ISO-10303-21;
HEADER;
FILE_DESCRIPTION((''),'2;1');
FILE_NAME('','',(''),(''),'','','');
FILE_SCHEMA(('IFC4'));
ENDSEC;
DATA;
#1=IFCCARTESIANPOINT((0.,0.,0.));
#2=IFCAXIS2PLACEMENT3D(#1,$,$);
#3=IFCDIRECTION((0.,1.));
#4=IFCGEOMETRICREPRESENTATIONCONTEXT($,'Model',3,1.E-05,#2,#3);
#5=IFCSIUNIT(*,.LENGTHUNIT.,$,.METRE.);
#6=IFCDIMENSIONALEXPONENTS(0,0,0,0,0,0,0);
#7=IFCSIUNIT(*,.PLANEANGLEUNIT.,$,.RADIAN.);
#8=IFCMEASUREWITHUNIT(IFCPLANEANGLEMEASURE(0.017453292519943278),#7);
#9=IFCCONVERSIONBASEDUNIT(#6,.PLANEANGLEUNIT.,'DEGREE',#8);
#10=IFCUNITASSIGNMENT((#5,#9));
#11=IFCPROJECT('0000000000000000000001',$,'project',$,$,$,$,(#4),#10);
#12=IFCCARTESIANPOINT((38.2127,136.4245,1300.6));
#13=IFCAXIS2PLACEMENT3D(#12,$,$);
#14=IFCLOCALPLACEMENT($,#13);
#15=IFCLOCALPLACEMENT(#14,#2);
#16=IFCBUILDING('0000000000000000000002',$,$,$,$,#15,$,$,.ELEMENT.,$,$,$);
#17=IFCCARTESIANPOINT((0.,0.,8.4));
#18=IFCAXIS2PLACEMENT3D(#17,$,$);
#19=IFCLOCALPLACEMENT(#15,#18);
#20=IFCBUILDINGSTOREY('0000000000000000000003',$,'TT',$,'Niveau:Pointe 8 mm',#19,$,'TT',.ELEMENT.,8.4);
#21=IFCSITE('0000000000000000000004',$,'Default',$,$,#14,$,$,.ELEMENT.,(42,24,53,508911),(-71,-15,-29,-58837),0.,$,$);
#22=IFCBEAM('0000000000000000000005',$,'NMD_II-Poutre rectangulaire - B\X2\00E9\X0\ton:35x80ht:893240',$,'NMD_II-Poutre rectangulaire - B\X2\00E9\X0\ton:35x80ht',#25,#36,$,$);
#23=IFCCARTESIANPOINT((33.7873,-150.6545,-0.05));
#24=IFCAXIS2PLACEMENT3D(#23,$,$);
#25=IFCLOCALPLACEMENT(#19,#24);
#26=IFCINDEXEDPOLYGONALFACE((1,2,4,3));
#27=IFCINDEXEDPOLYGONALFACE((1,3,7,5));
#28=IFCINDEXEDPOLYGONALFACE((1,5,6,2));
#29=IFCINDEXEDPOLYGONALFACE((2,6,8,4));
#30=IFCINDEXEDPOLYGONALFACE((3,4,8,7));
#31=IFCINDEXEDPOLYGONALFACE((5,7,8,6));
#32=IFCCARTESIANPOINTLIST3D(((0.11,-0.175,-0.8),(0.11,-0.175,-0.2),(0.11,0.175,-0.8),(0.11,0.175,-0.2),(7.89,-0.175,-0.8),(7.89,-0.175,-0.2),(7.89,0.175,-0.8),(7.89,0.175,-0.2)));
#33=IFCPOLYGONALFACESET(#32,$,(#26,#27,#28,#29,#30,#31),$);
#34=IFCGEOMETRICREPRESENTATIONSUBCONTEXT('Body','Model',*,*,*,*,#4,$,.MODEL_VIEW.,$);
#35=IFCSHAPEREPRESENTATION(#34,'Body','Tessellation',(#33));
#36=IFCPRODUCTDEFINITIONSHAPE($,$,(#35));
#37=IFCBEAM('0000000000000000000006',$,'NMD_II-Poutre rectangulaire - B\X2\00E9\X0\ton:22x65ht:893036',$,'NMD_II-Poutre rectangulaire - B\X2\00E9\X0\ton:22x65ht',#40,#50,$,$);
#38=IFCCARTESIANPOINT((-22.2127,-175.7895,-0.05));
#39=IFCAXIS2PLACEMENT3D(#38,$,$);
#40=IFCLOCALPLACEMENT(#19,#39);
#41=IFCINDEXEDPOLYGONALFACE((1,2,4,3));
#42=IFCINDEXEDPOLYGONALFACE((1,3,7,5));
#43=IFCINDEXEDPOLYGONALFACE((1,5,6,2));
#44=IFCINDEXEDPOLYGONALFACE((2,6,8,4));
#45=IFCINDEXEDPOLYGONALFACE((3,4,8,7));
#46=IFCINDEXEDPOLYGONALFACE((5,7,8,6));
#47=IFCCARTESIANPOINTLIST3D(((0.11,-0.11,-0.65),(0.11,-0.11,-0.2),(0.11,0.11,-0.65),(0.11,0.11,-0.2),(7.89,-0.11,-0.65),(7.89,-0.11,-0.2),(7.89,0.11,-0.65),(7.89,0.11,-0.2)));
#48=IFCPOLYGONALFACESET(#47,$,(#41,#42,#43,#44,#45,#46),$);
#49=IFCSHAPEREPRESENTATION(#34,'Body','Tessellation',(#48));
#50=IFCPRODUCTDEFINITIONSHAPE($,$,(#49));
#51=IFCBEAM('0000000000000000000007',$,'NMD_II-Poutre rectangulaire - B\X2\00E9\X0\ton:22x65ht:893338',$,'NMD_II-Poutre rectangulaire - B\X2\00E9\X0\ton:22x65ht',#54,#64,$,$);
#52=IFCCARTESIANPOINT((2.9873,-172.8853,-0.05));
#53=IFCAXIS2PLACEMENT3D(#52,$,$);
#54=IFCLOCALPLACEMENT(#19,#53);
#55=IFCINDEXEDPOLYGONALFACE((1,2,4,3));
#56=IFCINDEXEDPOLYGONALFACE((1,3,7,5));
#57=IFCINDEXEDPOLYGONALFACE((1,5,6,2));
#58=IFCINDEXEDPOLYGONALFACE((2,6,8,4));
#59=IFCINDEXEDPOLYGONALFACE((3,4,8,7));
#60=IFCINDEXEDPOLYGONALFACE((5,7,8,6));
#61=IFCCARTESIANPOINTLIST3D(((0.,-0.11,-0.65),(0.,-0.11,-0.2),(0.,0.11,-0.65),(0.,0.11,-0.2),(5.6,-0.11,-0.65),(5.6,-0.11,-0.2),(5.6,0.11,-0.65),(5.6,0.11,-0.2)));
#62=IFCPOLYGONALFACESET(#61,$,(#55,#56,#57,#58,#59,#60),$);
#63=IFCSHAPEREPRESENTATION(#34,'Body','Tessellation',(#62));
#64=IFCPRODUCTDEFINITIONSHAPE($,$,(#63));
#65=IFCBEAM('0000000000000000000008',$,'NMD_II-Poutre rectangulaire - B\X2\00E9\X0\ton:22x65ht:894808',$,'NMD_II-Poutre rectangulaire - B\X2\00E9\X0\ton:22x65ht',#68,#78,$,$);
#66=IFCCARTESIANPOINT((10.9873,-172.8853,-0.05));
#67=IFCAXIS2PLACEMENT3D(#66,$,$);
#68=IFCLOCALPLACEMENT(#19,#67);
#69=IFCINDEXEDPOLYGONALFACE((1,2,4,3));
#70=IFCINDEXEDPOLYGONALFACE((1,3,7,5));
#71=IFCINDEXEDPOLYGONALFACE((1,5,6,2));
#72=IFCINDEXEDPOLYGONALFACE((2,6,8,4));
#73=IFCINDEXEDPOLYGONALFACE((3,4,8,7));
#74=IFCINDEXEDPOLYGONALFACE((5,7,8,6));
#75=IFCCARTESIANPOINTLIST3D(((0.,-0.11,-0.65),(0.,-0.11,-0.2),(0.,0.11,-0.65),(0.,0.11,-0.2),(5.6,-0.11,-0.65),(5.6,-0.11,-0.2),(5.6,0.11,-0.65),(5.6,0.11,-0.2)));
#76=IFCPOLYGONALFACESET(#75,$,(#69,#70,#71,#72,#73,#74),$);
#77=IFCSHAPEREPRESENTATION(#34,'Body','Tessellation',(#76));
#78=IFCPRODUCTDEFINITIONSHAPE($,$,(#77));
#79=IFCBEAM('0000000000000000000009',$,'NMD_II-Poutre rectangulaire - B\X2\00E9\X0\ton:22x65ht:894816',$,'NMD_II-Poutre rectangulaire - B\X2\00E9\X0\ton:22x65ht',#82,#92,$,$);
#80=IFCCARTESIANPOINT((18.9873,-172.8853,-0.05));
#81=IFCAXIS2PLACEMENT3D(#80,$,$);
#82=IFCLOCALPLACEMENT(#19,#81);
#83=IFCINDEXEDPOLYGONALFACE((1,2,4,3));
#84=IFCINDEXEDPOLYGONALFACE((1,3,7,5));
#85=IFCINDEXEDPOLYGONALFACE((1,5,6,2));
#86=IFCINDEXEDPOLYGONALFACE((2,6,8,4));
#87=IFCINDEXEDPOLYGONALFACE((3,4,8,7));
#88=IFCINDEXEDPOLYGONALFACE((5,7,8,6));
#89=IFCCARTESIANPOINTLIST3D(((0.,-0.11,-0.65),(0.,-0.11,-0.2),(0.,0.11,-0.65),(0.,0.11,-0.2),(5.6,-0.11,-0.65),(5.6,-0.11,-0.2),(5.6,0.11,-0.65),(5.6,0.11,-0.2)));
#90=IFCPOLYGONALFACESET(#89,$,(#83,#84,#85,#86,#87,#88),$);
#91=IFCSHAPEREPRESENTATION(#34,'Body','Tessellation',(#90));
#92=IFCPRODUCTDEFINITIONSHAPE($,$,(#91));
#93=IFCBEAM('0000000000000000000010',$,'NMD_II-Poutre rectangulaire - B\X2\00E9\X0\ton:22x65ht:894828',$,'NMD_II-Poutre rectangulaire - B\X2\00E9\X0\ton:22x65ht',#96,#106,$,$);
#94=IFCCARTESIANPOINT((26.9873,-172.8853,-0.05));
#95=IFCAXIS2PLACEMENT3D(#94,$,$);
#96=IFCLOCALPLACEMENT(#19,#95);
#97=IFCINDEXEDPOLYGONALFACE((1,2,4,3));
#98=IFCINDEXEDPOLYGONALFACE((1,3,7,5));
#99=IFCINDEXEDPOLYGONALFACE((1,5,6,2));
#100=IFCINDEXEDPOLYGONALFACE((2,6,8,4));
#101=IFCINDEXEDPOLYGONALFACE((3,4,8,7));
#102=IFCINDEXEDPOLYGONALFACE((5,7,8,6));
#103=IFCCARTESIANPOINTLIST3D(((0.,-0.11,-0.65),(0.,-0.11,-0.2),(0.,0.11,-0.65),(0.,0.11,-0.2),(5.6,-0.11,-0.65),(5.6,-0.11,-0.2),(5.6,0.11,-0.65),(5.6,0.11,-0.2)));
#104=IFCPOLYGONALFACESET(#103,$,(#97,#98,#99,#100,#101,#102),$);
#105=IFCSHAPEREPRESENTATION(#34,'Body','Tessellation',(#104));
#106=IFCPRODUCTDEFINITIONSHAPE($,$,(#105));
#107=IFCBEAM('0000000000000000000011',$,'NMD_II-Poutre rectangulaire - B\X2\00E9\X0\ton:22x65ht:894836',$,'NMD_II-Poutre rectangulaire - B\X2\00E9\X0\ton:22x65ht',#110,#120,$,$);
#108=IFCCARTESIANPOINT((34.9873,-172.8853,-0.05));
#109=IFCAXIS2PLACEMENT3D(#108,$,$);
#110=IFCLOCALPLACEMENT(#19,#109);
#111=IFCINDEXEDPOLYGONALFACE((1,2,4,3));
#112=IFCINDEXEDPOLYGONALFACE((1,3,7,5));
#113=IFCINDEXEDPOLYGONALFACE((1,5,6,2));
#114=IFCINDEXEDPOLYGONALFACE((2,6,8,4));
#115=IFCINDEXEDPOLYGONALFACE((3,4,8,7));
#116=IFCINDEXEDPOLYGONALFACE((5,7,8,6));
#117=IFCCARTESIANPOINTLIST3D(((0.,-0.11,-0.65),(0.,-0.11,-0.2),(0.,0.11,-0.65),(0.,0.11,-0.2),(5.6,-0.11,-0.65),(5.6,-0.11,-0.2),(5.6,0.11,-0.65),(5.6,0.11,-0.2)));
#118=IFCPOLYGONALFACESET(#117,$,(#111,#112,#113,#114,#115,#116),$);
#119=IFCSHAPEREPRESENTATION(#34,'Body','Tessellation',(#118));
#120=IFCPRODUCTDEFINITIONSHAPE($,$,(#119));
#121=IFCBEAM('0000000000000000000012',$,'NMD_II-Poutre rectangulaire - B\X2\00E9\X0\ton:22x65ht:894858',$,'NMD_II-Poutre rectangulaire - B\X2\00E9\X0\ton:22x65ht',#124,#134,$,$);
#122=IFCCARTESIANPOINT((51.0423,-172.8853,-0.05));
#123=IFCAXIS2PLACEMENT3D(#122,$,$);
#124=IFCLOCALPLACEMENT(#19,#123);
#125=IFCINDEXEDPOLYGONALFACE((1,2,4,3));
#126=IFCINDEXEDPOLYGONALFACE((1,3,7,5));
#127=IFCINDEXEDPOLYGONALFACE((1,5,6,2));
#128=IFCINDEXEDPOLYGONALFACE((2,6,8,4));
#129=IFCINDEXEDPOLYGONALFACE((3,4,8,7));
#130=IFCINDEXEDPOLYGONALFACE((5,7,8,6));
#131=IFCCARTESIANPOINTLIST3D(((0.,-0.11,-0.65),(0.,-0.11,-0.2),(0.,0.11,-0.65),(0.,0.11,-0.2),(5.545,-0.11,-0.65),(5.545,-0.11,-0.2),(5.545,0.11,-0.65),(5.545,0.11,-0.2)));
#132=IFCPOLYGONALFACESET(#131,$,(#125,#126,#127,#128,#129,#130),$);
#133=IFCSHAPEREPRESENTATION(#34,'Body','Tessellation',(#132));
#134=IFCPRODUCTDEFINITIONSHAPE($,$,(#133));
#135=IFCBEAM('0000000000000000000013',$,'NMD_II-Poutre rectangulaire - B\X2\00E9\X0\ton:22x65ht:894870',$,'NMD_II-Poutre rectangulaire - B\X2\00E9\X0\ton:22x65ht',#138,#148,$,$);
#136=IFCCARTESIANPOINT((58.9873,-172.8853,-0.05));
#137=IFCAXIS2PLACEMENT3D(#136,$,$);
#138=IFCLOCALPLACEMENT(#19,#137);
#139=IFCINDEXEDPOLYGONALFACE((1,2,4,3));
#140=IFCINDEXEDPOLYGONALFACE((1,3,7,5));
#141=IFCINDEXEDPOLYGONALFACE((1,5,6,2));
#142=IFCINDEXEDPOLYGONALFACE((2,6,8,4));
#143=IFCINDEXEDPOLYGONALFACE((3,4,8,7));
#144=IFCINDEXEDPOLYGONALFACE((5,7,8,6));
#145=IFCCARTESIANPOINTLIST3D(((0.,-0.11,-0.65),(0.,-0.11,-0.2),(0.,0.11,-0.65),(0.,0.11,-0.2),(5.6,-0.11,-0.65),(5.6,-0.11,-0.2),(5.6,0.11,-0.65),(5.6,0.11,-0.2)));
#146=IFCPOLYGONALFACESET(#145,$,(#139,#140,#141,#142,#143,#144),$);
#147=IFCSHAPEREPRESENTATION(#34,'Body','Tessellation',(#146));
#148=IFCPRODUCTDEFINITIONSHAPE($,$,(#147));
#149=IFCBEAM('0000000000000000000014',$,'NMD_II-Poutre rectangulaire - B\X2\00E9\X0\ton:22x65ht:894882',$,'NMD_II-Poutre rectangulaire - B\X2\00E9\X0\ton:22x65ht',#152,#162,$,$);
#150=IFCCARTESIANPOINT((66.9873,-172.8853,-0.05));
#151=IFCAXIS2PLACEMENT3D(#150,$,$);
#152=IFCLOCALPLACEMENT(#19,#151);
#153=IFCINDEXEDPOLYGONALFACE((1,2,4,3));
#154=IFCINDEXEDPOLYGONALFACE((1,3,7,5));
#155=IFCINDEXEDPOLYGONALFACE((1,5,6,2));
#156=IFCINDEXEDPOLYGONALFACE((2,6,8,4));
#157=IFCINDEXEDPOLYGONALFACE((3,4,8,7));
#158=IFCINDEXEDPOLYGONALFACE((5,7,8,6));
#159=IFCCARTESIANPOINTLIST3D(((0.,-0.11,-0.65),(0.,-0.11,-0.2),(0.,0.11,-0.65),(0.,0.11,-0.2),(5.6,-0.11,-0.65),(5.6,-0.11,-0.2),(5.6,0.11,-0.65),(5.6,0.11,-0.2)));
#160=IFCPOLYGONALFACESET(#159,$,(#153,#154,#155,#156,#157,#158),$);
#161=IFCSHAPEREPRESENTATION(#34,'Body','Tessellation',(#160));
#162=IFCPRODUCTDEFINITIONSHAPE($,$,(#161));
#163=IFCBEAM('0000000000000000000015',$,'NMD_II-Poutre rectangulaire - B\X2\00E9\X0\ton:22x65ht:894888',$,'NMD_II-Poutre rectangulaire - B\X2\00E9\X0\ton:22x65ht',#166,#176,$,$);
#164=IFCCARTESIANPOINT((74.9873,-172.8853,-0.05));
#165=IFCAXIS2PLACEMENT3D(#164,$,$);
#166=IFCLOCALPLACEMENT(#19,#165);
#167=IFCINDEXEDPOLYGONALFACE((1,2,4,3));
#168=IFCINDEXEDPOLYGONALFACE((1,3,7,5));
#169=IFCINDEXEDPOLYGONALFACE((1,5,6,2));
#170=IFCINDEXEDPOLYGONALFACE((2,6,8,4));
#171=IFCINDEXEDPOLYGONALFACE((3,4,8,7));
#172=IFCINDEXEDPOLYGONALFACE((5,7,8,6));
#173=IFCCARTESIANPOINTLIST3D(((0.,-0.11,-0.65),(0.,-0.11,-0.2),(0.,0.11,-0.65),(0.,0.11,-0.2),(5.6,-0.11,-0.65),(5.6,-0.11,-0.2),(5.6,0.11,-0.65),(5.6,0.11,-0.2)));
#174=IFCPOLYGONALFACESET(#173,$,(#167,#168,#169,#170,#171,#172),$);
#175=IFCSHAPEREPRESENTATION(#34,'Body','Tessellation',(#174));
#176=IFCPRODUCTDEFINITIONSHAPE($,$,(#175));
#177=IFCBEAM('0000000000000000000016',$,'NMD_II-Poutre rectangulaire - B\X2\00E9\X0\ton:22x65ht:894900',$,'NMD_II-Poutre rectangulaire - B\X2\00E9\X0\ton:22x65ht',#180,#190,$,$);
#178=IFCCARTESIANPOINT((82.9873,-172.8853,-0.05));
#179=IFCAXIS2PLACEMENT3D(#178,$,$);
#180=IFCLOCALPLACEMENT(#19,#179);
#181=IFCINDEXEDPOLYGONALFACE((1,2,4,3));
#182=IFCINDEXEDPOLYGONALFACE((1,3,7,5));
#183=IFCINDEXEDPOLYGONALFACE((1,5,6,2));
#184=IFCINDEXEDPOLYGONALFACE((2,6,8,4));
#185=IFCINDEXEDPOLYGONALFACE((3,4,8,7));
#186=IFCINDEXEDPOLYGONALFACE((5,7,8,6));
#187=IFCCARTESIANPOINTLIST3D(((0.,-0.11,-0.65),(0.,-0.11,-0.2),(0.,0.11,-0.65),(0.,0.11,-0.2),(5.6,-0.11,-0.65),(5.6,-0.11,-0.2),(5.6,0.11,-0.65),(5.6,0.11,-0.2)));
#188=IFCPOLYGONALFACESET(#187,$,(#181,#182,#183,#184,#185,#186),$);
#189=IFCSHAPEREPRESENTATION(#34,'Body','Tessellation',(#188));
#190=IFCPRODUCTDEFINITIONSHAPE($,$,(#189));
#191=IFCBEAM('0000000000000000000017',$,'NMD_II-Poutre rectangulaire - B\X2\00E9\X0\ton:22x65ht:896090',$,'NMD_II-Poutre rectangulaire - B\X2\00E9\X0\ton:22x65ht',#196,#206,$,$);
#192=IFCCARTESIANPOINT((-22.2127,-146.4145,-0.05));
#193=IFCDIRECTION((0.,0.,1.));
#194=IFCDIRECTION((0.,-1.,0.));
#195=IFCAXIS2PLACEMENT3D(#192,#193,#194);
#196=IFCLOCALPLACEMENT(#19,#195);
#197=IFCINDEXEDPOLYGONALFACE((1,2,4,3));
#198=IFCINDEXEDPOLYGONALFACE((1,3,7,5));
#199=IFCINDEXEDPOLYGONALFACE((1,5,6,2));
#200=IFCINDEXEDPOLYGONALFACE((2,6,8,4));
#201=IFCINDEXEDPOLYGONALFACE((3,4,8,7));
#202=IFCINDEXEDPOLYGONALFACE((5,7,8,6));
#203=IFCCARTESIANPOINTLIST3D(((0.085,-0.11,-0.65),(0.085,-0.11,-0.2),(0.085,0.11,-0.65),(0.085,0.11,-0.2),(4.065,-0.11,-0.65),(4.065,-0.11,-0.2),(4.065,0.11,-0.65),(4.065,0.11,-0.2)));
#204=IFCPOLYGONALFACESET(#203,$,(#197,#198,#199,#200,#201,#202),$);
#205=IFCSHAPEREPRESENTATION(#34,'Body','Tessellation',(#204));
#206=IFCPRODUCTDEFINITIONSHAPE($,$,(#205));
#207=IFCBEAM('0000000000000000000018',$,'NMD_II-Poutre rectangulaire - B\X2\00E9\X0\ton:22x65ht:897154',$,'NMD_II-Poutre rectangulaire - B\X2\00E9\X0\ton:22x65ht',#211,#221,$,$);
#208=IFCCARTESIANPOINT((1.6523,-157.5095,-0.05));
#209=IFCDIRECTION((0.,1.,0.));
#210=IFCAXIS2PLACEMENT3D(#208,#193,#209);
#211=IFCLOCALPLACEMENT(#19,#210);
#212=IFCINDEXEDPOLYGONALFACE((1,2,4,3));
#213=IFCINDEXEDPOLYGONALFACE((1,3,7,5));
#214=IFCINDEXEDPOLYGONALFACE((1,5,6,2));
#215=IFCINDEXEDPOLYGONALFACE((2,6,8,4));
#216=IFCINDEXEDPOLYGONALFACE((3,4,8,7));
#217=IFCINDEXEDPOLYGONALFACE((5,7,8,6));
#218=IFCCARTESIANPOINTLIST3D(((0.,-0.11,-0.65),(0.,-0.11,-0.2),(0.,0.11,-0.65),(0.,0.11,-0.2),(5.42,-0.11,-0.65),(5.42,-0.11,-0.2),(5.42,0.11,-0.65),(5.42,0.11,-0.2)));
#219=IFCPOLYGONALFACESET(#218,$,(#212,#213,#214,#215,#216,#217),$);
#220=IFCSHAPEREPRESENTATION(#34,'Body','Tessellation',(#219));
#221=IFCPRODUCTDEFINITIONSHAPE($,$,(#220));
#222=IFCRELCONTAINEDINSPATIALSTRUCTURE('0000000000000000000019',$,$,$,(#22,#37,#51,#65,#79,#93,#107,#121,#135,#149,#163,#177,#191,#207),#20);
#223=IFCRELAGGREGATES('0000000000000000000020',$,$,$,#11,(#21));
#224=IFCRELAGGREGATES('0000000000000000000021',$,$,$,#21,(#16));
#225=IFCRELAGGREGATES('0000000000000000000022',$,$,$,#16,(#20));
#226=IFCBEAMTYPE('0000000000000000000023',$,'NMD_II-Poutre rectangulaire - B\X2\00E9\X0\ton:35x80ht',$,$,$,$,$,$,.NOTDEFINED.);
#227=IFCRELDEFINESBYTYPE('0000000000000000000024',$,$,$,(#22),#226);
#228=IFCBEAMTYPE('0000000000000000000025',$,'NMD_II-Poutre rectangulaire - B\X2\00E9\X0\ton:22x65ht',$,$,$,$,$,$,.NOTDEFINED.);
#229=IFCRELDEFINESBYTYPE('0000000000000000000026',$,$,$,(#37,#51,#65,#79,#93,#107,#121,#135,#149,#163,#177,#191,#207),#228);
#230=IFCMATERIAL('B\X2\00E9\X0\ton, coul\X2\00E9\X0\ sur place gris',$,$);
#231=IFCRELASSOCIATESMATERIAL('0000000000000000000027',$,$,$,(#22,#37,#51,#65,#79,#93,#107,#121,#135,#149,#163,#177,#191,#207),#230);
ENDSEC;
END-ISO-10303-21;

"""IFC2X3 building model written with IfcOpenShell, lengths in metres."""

from ifc_helpers import new_model, entity, si_unit, converted_unit, direction, frame, frame_2d, origin, place, context, subcontext, project, spatial, rectangle, extrude, material, type_object, element, save


model = new_model("IFC2X3")

# Units and contexts
model_context = context("Model", 3, precision=1e-05, world=origin(), true_north=direction((0.0, 1.0)))
body_context = subcontext(model_context, "Body", "Model", "MODEL_VIEW")
ifc_project = project(units=[si_unit("LENGTHUNIT", "METRE"), converted_unit("PLANEANGLEUNIT", "DEGREE", entity("IfcPlaneAngleMeasure", 0.017453292519943278), si_unit("PLANEANGLEUNIT", "RADIAN"), dimensions=[0, 0, 0, 0, 0, 0, 0])], contexts=[model_context])

# Site, building, storey
site_placement = place(None, frame((38.2127, 136.4245, 1300.6)))
site = spatial("IfcSite", under=ifc_project, at=site_placement, Name="Default", CompositionType="ELEMENT", RefLatitude=(42, 24, 53, 508911), RefLongitude=(-71, -15, -29, -58837), RefElevation=0.0)
building_placement = place(site_placement, origin())
building = spatial("IfcBuilding", under=site, at=building_placement, CompositionType="ELEMENT")
storey_placement = place(building_placement, frame((0.0, 0.0, 8.4)))
storey = spatial("IfcBuildingStorey", under=building, at=storey_placement, Name="TT", ObjectType="Niveau:Pointe 8 mm", LongName="TT", CompositionType="ELEMENT", Elevation=8.4)

# Beams
ifc_material_1 = material(Name="Béton, coulé sur place gris")
beam_type_1 = type_object("IfcBeamType", Name="NMD_II-Poutre rectangulaire - Béton:35x80ht", PredefinedType="NOTDEFINED")
beam_1_placement = place(storey_placement, frame((33.7873, -150.6545, -0.05)))
element("IfcBeam", 1, at=beam_1_placement, inside=storey, type_object=beam_type_1, material=ifc_material_1, Name="NMD_II-Poutre rectangulaire - Béton:35x80ht:893240", ObjectType="NMD_II-Poutre rectangulaire - Béton:35x80ht", context=body_context, shape_type="SweptSolid", body=[
    extrude(rectangle(XDim=0.6, YDim=0.35, at=frame_2d((0.0, 0.0), x_axis=(1.0, 0.0))), frame((0.11, 0.0, -0.5), z_axis=(1.0, 0.0, 0.0), x_axis=(0.0, 0.0, -1.0)), (0.0, 0.0, 1.0), 7.78),
])
beam_type_2 = type_object("IfcBeamType", Name="NMD_II-Poutre rectangulaire - Béton:22x65ht", PredefinedType="NOTDEFINED")
beam_2_placement = place(storey_placement, frame((-22.2127, -175.7895, -0.05)))
element("IfcBeam", 2, at=beam_2_placement, inside=storey, type_object=beam_type_2, material=ifc_material_1, Name="NMD_II-Poutre rectangulaire - Béton:22x65ht:893036", ObjectType="NMD_II-Poutre rectangulaire - Béton:22x65ht", context=body_context, shape_type="SweptSolid", body=[
    extrude(rectangle(XDim=0.45, YDim=0.22, at=frame_2d((0.0, 0.0), x_axis=(1.0, 0.0))), frame((0.11, 0.0, -0.425), z_axis=(1.0, 0.0, 0.0), x_axis=(0.0, 0.0, -1.0)), (0.0, 0.0, 1.0), 7.78),
])
beam_3_placement = place(storey_placement, frame((2.9873, -172.8853, -0.05)))
element("IfcBeam", 3, at=beam_3_placement, inside=storey, type_object=beam_type_2, material=ifc_material_1, Name="NMD_II-Poutre rectangulaire - Béton:22x65ht:893338", ObjectType="NMD_II-Poutre rectangulaire - Béton:22x65ht", context=body_context, shape_type="SweptSolid", body=[
    extrude(rectangle(XDim=0.45, YDim=0.22, at=frame_2d((0.0, 0.0), x_axis=(1.0, 0.0))), frame((0.0, 0.0, -0.425), z_axis=(1.0, 0.0, 0.0), x_axis=(0.0, 0.0, -1.0)), (0.0, 0.0, 1.0), 5.6),
])
beam_4_placement = place(storey_placement, frame((10.9873, -172.8853, -0.05)))
element("IfcBeam", 4, at=beam_4_placement, inside=storey, type_object=beam_type_2, material=ifc_material_1, Name="NMD_II-Poutre rectangulaire - Béton:22x65ht:894808", ObjectType="NMD_II-Poutre rectangulaire - Béton:22x65ht", context=body_context, shape_type="SweptSolid", body=[
    extrude(rectangle(XDim=0.45, YDim=0.22, at=frame_2d((0.0, 0.0), x_axis=(1.0, 0.0))), frame((0.0, 0.0, -0.425), z_axis=(1.0, 0.0, 0.0), x_axis=(0.0, 0.0, -1.0)), (0.0, 0.0, 1.0), 5.6),
])
for number, where, name in (
    (5, (18.9873, -172.8853, -0.05), "NMD_II-Poutre rectangulaire - Béton:22x65ht:894816"),
    (6, (26.9873, -172.8853, -0.05), "NMD_II-Poutre rectangulaire - Béton:22x65ht:894828"),
):
    element("IfcBeam", number, at=place(storey_placement, frame(where)), inside=storey, type_object=beam_type_2, material=ifc_material_1, Name=name, ObjectType="NMD_II-Poutre rectangulaire - Béton:22x65ht", context=body_context, shape_type="SweptSolid", body=[
        extrude(rectangle(XDim=0.45, YDim=0.22, at=frame_2d((0.0, 0.0), x_axis=(1.0, 0.0))), frame((0.0, 0.0, -0.425), z_axis=(1.0, 0.0, 0.0), x_axis=(0.0, 0.0, -1.0)), (0.0, 0.0, 1.0), 5.6),
    ])
beam_5_placement = place(storey_placement, frame((34.9873, -172.8853, -0.05)))
element("IfcBeam", 7, at=beam_5_placement, inside=storey, type_object=beam_type_2, material=ifc_material_1, Name="NMD_II-Poutre rectangulaire - Béton:22x65ht:894836", ObjectType="NMD_II-Poutre rectangulaire - Béton:22x65ht", context=body_context, shape_type="SweptSolid", body=[
    extrude(rectangle(XDim=0.45, YDim=0.22, at=frame_2d((0.0, 0.0), x_axis=(1.0, 0.0))), frame((0.0, 0.0, -0.425), z_axis=(1.0, 0.0, 0.0), x_axis=(0.0, 0.0, -1.0)), (0.0, 0.0, 1.0), 5.6),
])
beam_6_placement = place(storey_placement, frame((51.0423, -172.8853, -0.05)))
element("IfcBeam", 8, at=beam_6_placement, inside=storey, type_object=beam_type_2, material=ifc_material_1, Name="NMD_II-Poutre rectangulaire - Béton:22x65ht:894858", ObjectType="NMD_II-Poutre rectangulaire - Béton:22x65ht", context=body_context, shape_type="SweptSolid", body=[
    extrude(rectangle(XDim=0.45, YDim=0.22, at=frame_2d((0.0, 0.0), x_axis=(1.0, 0.0))), frame((0.0, 0.0, -0.425), z_axis=(1.0, 0.0, 0.0), x_axis=(0.0, 0.0, -1.0)), (0.0, 0.0, 1.0), 5.545),
])
beam_7_placement = place(storey_placement, frame((58.9873, -172.8853, -0.05)))
element("IfcBeam", 9, at=beam_7_placement, inside=storey, type_object=beam_type_2, material=ifc_material_1, Name="NMD_II-Poutre rectangulaire - Béton:22x65ht:894870", ObjectType="NMD_II-Poutre rectangulaire - Béton:22x65ht", context=body_context, shape_type="SweptSolid", body=[
    extrude(rectangle(XDim=0.45, YDim=0.22, at=frame_2d((0.0, 0.0), x_axis=(1.0, 0.0))), frame((0.0, 0.0, -0.425), z_axis=(1.0, 0.0, 0.0), x_axis=(0.0, 0.0, -1.0)), (0.0, 0.0, 1.0), 5.6),
])
beam_8_placement = place(storey_placement, frame((66.9873, -172.8853, -0.05)))
element("IfcBeam", 10, at=beam_8_placement, inside=storey, type_object=beam_type_2, material=ifc_material_1, Name="NMD_II-Poutre rectangulaire - Béton:22x65ht:894882", ObjectType="NMD_II-Poutre rectangulaire - Béton:22x65ht", context=body_context, shape_type="SweptSolid", body=[
    extrude(rectangle(XDim=0.45, YDim=0.22, at=frame_2d((0.0, 0.0), x_axis=(1.0, 0.0))), frame((0.0, 0.0, -0.425), z_axis=(1.0, 0.0, 0.0), x_axis=(0.0, 0.0, -1.0)), (0.0, 0.0, 1.0), 5.6),
])
beam_9_placement = place(storey_placement, frame((74.9873, -172.8853, -0.05)))
element("IfcBeam", 11, at=beam_9_placement, inside=storey, type_object=beam_type_2, material=ifc_material_1, Name="NMD_II-Poutre rectangulaire - Béton:22x65ht:894888", ObjectType="NMD_II-Poutre rectangulaire - Béton:22x65ht", context=body_context, shape_type="SweptSolid", body=[
    extrude(rectangle(XDim=0.45, YDim=0.22, at=frame_2d((0.0, 0.0), x_axis=(1.0, 0.0))), frame((0.0, 0.0, -0.425), z_axis=(1.0, 0.0, 0.0), x_axis=(0.0, 0.0, -1.0)), (0.0, 0.0, 1.0), 5.6),
])
beam_10_placement = place(storey_placement, frame((82.9873, -172.8853, -0.05)))
element("IfcBeam", 12, at=beam_10_placement, inside=storey, type_object=beam_type_2, material=ifc_material_1, Name="NMD_II-Poutre rectangulaire - Béton:22x65ht:894900", ObjectType="NMD_II-Poutre rectangulaire - Béton:22x65ht", context=body_context, shape_type="SweptSolid", body=[
    extrude(rectangle(XDim=0.45, YDim=0.22, at=frame_2d((0.0, 0.0), x_axis=(1.0, 0.0))), frame((0.0, 0.0, -0.425), z_axis=(1.0, 0.0, 0.0), x_axis=(0.0, 0.0, -1.0)), (0.0, 0.0, 1.0), 5.6),
])
beam_11_placement = place(storey_placement, frame((-22.2127, -146.4145, -0.05), z_axis=(0.0, 0.0, 1.0), x_axis=(0.0, -1.0, 0.0)))
element("IfcBeam", 13, at=beam_11_placement, inside=storey, type_object=beam_type_2, material=ifc_material_1, Name="NMD_II-Poutre rectangulaire - Béton:22x65ht:896090", ObjectType="NMD_II-Poutre rectangulaire - Béton:22x65ht", context=body_context, shape_type="SweptSolid", body=[
    extrude(rectangle(XDim=0.45, YDim=0.22, at=frame_2d((0.0, 0.0), x_axis=(1.0, 0.0))), frame((0.085, 0.0, -0.425), z_axis=(1.0, 0.0, 0.0), x_axis=(0.0, 0.0, -1.0)), (0.0, 0.0, 1.0), 3.98),
])
beam_12_placement = place(storey_placement, frame((1.6523, -157.5095, -0.05), z_axis=(0.0, 0.0, 1.0), x_axis=(0.0, 1.0, 0.0)))
element("IfcBeam", 14, at=beam_12_placement, inside=storey, type_object=beam_type_2, material=ifc_material_1, Name="NMD_II-Poutre rectangulaire - Béton:22x65ht:897154", ObjectType="NMD_II-Poutre rectangulaire - Béton:22x65ht", context=body_context, shape_type="SweptSolid", body=[
    extrude(rectangle(XDim=0.45, YDim=0.22, at=frame_2d((0.0, 0.0), x_axis=(1.0, 0.0))), frame((0.0, 0.0, -0.425), z_axis=(1.0, 0.0, 0.0), x_axis=(0.0, 0.0, -1.0)), (0.0, 0.0, 1.0), 5.42),
])

save(model, "model.ifc")
